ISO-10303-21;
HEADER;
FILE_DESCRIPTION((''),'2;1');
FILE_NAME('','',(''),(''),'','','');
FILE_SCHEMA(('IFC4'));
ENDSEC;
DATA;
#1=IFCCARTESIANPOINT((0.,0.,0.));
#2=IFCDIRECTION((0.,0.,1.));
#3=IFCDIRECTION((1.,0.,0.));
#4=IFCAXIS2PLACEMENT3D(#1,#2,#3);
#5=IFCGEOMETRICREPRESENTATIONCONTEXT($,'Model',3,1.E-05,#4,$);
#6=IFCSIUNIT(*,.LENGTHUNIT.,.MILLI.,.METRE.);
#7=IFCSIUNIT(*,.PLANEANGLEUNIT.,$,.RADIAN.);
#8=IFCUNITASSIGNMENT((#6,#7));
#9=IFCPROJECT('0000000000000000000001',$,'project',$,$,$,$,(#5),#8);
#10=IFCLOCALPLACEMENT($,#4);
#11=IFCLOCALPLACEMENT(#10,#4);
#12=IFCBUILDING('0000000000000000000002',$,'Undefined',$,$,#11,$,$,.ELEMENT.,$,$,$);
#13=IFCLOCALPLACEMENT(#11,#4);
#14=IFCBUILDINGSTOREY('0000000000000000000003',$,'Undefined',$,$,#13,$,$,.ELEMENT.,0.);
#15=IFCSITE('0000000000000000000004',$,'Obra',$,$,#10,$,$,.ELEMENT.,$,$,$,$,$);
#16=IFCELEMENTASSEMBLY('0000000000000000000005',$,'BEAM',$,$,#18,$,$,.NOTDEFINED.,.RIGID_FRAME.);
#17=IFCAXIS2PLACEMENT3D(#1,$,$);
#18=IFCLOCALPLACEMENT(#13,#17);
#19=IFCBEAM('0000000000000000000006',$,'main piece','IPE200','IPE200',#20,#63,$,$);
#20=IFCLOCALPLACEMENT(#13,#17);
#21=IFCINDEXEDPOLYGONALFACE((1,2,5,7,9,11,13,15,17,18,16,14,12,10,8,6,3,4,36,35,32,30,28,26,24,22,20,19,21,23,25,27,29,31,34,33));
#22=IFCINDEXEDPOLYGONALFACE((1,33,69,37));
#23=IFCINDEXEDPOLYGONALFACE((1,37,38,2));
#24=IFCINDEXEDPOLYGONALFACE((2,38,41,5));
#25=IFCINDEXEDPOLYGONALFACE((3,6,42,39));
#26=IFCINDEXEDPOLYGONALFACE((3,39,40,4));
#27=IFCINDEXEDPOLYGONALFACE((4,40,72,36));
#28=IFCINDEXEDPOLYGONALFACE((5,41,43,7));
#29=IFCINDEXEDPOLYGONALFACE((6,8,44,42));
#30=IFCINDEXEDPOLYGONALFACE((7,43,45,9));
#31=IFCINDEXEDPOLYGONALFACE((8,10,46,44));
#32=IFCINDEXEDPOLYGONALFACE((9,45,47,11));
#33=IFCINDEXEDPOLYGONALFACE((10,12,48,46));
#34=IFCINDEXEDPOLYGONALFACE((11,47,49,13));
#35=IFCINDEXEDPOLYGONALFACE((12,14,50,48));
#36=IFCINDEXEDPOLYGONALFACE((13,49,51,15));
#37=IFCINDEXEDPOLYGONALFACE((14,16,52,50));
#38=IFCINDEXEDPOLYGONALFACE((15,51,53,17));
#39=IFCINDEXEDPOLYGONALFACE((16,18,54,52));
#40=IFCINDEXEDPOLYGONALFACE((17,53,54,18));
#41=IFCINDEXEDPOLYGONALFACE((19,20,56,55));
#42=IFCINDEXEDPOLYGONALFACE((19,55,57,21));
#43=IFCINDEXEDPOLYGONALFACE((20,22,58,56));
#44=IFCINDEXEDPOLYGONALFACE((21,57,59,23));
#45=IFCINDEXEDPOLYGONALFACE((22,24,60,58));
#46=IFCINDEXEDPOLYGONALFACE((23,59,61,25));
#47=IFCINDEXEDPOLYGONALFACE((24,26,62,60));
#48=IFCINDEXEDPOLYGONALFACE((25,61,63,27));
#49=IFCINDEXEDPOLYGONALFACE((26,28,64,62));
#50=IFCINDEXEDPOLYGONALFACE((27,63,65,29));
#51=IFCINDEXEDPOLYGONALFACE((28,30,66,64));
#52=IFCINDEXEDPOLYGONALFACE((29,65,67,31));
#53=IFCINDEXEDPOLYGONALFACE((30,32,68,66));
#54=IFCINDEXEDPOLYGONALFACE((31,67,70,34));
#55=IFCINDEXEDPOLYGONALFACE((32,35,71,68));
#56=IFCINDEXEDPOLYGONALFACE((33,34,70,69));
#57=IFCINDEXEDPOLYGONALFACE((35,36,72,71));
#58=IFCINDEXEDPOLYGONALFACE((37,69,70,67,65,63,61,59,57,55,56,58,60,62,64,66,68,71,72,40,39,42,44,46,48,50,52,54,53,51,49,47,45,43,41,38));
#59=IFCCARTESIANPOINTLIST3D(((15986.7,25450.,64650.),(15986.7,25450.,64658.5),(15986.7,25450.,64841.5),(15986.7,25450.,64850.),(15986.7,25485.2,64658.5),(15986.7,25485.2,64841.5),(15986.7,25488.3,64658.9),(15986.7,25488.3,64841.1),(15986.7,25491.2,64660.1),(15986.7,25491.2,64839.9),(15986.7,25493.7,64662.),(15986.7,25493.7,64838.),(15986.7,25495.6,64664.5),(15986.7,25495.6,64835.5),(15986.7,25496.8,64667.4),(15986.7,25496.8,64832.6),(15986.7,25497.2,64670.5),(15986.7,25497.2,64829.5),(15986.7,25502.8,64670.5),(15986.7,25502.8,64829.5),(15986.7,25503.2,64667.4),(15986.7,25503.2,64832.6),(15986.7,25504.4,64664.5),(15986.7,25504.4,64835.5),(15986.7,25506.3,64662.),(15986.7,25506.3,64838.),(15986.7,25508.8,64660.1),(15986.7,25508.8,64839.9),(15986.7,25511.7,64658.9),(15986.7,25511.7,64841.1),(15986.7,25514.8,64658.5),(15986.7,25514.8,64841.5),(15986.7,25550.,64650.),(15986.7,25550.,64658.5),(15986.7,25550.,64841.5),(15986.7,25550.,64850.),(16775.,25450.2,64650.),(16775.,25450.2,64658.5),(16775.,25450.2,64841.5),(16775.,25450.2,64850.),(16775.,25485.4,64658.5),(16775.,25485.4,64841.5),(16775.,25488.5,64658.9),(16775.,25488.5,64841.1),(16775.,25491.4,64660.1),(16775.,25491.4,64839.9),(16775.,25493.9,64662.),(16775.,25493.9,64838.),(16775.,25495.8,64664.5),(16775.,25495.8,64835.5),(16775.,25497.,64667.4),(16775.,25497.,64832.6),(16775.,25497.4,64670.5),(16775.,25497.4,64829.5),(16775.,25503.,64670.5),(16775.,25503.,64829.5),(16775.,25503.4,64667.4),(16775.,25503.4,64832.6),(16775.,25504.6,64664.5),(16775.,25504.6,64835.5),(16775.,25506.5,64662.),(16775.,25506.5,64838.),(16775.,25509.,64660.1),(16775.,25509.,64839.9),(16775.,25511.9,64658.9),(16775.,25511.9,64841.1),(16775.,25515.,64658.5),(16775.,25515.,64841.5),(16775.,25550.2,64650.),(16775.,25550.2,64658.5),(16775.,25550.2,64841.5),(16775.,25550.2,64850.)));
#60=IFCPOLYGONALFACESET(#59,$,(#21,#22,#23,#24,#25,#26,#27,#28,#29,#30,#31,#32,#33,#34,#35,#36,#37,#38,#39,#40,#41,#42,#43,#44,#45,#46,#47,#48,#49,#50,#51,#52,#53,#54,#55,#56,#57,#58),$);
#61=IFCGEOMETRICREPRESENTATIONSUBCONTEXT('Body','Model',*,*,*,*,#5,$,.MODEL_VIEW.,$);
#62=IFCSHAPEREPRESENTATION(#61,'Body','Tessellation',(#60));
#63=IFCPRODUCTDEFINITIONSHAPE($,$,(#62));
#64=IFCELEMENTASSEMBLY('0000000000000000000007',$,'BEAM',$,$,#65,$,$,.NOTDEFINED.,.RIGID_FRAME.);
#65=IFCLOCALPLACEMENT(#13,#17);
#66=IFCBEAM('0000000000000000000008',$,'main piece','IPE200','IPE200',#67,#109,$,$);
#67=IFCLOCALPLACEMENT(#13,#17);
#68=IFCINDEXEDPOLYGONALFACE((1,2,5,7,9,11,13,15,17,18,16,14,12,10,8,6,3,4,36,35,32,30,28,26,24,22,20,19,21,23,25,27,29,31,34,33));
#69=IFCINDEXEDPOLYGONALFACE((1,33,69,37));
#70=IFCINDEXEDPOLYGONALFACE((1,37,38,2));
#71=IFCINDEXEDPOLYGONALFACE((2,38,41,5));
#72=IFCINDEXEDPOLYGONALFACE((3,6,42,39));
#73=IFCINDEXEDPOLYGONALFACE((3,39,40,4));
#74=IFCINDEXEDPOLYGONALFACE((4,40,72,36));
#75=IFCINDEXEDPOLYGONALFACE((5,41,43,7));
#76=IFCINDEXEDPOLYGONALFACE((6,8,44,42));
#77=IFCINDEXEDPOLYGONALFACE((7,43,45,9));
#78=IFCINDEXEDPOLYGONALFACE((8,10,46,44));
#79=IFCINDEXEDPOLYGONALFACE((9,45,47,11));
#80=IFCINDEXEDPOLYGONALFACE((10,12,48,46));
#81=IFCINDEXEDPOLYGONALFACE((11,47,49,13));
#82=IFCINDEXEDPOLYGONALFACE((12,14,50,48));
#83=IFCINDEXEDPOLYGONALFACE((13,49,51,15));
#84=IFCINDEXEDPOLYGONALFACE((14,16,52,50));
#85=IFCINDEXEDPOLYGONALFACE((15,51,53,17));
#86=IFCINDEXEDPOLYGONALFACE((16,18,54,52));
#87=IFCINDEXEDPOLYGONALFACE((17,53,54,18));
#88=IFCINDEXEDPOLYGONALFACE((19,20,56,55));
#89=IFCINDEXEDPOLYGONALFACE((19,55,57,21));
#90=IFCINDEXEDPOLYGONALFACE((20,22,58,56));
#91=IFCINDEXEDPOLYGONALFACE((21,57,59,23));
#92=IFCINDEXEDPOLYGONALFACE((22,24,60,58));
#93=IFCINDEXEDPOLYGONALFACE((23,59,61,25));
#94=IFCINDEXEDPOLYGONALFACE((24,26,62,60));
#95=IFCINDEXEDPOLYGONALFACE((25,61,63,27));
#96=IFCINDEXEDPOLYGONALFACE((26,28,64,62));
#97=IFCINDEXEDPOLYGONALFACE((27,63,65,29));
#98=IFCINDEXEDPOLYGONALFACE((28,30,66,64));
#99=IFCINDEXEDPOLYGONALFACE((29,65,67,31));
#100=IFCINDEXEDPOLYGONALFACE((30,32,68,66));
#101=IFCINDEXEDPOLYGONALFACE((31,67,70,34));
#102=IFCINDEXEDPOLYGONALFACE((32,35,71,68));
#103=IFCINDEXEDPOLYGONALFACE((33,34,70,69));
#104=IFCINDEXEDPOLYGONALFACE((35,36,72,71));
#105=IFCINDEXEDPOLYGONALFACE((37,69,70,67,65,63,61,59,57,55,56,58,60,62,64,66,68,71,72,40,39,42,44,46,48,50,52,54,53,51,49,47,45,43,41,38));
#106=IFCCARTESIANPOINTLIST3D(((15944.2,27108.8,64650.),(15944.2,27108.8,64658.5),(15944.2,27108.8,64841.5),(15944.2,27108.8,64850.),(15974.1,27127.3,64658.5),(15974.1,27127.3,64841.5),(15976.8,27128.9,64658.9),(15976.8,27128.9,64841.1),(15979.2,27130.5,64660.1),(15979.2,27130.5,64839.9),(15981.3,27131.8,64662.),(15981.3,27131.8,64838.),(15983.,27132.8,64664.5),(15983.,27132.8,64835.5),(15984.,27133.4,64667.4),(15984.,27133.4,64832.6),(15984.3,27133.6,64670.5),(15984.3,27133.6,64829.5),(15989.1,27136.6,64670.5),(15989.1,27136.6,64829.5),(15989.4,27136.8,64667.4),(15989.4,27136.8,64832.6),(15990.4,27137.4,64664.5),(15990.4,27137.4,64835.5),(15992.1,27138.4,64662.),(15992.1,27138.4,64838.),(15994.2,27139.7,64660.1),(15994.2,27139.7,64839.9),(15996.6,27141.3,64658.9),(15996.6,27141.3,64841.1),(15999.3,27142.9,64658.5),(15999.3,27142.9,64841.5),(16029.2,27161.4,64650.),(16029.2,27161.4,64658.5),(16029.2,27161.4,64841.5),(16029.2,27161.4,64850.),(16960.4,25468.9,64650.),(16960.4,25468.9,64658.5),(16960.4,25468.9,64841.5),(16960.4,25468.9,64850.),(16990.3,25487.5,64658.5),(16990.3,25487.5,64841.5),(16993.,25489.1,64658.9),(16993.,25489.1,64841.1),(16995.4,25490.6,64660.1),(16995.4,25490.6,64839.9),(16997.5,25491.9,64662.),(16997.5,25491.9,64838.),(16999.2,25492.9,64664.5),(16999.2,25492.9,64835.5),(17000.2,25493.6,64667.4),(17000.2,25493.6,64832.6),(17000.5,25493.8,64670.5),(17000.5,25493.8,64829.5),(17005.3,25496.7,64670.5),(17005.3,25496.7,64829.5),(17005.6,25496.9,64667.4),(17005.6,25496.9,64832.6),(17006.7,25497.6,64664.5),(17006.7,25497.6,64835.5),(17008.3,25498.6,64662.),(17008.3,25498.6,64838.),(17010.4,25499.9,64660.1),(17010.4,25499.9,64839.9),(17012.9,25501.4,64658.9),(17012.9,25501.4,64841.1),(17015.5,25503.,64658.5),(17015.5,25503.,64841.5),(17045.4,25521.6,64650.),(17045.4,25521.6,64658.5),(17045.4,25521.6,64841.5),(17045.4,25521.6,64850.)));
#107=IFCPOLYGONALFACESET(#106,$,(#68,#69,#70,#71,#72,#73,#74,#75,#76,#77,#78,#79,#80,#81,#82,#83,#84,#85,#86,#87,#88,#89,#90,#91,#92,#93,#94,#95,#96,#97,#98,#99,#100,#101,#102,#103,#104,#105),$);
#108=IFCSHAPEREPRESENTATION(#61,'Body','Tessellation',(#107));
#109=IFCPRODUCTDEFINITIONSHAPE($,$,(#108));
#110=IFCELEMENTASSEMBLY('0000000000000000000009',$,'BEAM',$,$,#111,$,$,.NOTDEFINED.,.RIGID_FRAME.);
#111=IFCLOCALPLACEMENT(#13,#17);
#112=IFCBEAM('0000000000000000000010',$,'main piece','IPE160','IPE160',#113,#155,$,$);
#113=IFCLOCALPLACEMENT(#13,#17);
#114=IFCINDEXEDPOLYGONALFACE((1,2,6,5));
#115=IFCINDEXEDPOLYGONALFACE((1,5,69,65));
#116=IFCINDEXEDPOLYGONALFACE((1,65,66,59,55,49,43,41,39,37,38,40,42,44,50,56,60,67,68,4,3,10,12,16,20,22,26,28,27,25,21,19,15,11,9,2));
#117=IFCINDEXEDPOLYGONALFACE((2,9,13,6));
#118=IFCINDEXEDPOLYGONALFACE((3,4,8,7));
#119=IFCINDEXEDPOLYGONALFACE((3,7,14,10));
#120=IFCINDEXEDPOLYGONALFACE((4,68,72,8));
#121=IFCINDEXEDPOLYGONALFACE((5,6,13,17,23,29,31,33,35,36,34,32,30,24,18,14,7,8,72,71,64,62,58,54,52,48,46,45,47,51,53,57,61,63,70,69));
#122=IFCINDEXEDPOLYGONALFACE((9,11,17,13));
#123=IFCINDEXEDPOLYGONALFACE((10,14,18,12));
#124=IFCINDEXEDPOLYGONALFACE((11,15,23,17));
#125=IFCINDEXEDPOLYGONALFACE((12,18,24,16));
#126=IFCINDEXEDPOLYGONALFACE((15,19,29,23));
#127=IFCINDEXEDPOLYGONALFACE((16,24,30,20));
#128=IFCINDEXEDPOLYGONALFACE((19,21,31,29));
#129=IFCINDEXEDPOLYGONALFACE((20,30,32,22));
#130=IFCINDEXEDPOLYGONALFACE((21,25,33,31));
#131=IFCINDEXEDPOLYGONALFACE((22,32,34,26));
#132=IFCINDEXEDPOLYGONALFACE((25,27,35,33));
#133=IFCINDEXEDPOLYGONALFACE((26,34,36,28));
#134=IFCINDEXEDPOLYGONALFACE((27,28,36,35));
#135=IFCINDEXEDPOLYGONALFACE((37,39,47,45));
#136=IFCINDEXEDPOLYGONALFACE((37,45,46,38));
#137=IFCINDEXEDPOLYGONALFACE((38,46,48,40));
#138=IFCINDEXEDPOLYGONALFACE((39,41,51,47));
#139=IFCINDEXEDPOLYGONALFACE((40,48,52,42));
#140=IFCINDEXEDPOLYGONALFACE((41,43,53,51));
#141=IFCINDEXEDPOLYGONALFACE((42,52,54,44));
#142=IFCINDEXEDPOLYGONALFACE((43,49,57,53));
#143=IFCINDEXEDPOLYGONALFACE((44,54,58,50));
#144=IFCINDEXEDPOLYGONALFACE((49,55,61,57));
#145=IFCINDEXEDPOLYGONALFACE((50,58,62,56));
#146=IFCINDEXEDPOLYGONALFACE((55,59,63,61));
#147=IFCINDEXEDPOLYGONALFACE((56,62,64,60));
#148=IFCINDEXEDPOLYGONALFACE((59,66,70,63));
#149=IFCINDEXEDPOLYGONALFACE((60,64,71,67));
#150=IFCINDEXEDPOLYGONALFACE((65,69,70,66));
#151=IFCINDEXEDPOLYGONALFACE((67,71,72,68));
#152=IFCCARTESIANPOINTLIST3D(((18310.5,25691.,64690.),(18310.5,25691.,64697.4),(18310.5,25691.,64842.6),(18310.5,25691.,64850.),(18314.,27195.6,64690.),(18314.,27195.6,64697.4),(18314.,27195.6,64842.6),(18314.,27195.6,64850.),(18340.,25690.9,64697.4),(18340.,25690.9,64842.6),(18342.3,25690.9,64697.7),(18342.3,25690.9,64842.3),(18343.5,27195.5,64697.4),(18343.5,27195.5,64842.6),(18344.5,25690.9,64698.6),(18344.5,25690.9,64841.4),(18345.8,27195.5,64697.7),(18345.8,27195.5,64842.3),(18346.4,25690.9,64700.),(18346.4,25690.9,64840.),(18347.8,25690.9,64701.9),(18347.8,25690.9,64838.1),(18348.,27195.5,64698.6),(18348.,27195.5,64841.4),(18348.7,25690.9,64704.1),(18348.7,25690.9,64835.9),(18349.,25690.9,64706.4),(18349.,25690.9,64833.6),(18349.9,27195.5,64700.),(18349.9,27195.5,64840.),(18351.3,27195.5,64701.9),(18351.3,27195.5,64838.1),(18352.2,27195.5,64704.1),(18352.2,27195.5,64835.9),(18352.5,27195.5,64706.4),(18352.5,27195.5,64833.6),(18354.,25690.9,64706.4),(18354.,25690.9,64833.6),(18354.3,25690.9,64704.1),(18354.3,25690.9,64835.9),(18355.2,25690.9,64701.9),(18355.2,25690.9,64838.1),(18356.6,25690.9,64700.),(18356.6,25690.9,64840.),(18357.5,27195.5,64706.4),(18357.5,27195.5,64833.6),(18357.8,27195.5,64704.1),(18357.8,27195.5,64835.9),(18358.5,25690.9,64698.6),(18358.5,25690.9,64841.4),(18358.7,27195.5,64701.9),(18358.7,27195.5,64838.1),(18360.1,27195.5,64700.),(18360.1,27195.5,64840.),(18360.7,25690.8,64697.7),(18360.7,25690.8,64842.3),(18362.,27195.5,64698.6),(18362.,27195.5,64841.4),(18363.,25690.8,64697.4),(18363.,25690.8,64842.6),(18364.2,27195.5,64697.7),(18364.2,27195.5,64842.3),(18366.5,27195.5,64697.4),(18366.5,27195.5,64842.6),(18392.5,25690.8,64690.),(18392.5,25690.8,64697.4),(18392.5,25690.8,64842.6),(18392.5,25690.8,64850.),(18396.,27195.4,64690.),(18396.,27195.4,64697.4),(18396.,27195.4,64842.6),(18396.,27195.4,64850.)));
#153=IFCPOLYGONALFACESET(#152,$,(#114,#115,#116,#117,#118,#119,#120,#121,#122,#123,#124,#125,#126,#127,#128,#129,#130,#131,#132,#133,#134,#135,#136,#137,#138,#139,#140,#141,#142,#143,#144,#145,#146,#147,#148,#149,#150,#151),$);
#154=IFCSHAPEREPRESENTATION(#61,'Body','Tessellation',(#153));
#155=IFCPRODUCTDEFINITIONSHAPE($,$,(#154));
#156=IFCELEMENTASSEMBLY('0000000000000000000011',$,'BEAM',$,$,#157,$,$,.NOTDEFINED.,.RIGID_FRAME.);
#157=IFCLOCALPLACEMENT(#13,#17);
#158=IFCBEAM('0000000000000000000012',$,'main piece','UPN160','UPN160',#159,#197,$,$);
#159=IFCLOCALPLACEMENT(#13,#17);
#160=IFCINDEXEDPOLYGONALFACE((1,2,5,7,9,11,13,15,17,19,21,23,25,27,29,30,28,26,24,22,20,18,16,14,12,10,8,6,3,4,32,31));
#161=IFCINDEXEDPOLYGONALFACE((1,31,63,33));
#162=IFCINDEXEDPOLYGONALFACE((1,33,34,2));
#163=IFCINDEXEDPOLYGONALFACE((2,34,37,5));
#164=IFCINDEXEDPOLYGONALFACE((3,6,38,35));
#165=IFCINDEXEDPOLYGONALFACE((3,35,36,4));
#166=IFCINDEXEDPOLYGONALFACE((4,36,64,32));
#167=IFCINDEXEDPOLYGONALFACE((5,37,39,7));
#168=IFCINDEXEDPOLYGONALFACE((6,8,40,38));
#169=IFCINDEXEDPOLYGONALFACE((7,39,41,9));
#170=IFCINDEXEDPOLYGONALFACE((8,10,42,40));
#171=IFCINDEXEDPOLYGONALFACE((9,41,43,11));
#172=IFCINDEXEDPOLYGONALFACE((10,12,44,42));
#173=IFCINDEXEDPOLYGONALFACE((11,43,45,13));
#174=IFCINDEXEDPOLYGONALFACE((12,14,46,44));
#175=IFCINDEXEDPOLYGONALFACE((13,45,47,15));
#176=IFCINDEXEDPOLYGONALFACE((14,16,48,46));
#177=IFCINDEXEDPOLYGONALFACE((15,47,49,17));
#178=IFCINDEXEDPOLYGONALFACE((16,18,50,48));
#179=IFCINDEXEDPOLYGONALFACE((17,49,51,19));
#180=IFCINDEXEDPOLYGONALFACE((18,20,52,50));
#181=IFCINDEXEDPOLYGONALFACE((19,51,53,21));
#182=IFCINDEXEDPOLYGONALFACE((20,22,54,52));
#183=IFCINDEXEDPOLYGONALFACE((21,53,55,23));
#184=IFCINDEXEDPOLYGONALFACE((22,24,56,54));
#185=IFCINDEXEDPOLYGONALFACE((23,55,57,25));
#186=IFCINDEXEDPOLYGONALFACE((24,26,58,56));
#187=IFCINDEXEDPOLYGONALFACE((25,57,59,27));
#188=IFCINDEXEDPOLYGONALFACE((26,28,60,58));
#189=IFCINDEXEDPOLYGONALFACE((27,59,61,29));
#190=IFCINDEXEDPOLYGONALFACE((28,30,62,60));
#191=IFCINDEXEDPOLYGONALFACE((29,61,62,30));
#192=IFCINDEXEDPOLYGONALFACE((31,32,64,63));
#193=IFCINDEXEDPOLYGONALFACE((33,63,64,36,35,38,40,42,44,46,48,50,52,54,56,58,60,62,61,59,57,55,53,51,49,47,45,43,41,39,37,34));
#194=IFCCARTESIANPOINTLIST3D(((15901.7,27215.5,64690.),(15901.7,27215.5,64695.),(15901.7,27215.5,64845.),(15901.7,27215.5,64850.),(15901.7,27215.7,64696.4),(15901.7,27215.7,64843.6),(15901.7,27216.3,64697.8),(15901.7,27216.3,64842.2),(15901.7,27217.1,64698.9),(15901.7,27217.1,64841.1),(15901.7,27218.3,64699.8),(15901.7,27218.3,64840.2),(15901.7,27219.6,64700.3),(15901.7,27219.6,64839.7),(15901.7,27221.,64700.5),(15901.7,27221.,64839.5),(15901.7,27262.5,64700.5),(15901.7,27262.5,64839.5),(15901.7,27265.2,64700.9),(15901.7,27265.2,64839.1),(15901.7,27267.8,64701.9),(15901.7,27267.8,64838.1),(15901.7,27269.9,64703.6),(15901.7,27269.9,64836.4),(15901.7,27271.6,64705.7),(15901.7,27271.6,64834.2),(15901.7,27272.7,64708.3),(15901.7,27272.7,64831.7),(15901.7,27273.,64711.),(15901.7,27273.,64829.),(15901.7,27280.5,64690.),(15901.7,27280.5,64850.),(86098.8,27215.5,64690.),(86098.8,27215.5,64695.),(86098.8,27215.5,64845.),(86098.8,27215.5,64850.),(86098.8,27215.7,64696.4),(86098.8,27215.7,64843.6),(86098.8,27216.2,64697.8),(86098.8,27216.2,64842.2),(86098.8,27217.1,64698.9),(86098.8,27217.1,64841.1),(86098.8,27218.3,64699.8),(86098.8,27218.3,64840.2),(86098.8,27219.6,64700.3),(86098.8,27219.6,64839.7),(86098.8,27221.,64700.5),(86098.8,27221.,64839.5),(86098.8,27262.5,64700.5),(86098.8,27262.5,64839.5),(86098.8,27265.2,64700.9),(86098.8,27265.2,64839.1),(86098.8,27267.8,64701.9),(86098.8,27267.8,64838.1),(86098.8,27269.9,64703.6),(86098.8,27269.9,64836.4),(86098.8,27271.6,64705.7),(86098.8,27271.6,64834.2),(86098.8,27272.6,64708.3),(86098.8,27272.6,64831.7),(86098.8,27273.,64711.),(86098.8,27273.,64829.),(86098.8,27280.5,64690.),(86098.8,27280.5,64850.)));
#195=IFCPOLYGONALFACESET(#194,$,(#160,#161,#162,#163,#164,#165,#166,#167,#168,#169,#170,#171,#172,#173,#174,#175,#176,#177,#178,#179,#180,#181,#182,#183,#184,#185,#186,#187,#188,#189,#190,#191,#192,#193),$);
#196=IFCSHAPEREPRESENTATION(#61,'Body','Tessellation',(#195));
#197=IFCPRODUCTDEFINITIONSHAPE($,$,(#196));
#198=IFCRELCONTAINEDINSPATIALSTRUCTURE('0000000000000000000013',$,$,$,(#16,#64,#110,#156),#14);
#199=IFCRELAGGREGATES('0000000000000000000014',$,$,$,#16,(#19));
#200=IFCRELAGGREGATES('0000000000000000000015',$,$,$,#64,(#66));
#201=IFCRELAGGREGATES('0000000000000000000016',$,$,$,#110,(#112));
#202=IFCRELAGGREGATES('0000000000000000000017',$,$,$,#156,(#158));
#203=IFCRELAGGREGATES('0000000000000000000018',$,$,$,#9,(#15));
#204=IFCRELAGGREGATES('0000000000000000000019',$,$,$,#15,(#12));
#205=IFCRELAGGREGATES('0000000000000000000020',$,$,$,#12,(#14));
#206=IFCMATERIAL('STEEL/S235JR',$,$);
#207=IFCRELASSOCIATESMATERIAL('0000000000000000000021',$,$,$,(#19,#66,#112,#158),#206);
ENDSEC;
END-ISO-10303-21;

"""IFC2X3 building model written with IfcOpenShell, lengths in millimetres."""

from ifc_helpers import new_model, si_unit, frame, origin_with_axes, origin_2d_with_axis, place, context, subcontext, project, spatial, i_section, u_section, extrude, material, element, aggregate, save


model = new_model("IFC2X3")

# Units and contexts
model_context = context("Model", 3, precision=1e-05, world=origin_with_axes())
body_context = subcontext(model_context, "Body", "Model", "MODEL_VIEW")
ifc_project = project(units=[si_unit("LENGTHUNIT", "METRE", prefix="MILLI"), si_unit("PLANEANGLEUNIT", "RADIAN")], contexts=[model_context])

# Site, building, storey
site_placement = place(None, origin_with_axes())
site = spatial("IfcSite", under=ifc_project, at=site_placement, Name="Obra", CompositionType="ELEMENT")
building_placement = place(site_placement, origin_with_axes())
building = spatial("IfcBuilding", under=site, at=building_placement, Name="Undefined", CompositionType="ELEMENT")
storey_placement = place(building_placement, origin_with_axes())
storey = spatial("IfcBuildingStorey", under=building, at=storey_placement, Name="Undefined", CompositionType="ELEMENT", Elevation=0.0)

# Shared definitions
ifc_material_1 = material(Name="STEEL/S235JR")

# Element assemblies, beams
assembly_1_placement = place(storey_placement, origin_with_axes())
assembly_1 = element("IfcElementAssembly", 1, at=assembly_1_placement, inside=storey, Name="BEAM", AssemblyPlace="NOTDEFINED", PredefinedType="RIGID_FRAME")
beam_1_placement = place(assembly_1_placement, frame((16775.0, 25500.2, 64750.0), z_axis=(0.0, 0.0, 1.0), x_axis=(-1.0, -0.000266, 0.0)))
beam_1 = element("IfcBeam", 2, at=beam_1_placement, material=ifc_material_1, Name="main piece", Description="IPE200", ObjectType="IPE200", context=body_context, shape_type="SweptSolid", body=[
    extrude(i_section(OverallWidth=100.0, OverallDepth=200.0, WebThickness=5.6, FlangeThickness=8.5, FilletRadius=12.0, at=origin_2d_with_axis()), frame((788.3, 0.0, 0.0), z_axis=(-1.0, 0.0, 0.0), x_axis=(0.0, -1.0, 0.0)), (0.0, 0.0, 1.0), 788.3),
])
aggregate(assembly_1, [beam_1])
assembly_2_placement = place(storey_placement, origin_with_axes())
assembly_2 = element("IfcElementAssembly", 3, at=assembly_2_placement, inside=storey, Name="BEAM", AssemblyPlace="NOTDEFINED", PredefinedType="RIGID_FRAME")
beam_2_placement = place(assembly_2_placement, frame((17002.9, 25495.3, 64750.0), z_axis=(0.0, 0.0, 1.0), x_axis=(-0.526756, 0.850017, 0.0)))
beam_2 = element("IfcBeam", 4, at=beam_2_placement, material=ifc_material_1, Name="main piece", Description="IPE200", ObjectType="IPE200", context=body_context, shape_type="SweptSolid", body=[
    extrude(i_section(OverallWidth=100.0, OverallDepth=200.0, WebThickness=5.6, FlangeThickness=8.5, FilletRadius=12.0, at=origin_2d_with_axis()), frame((1929.2, 0.0, 0.0), z_axis=(-1.0, 0.0, 0.0), x_axis=(0.0, -1.0, 0.0)), (0.0, 0.0, 1.0), 1929.2),
])
aggregate(assembly_2, [beam_2])
assembly_3_placement = place(storey_placement, origin_with_axes())
assembly_3 = element("IfcElementAssembly", 5, at=assembly_3_placement, inside=storey, Name="BEAM", AssemblyPlace="NOTDEFINED", PredefinedType="RIGID_FRAME")
beam_3_placement = place(assembly_3_placement, frame((18351.5, 25690.9, 64770.0), z_axis=(0.0, 0.0, 1.0), x_axis=(0.002325, 0.999997, 0.0)))
beam_3 = element("IfcBeam", 6, at=beam_3_placement, material=ifc_material_1, Name="main piece", Description="IPE160", ObjectType="IPE160", context=body_context, shape_type="SweptSolid", body=[
    extrude(i_section(OverallWidth=82.0, OverallDepth=160.0, WebThickness=5.0, FlangeThickness=7.4, FilletRadius=9.0, at=origin_2d_with_axis()), frame((1504.6, 0.0, 0.0), z_axis=(-1.0, 0.0, 0.0), x_axis=(0.0, -1.0, 0.0)), (0.0, 0.0, 1.0), 1504.6),
])
aggregate(assembly_3, [beam_3])
assembly_4_placement = place(storey_placement, origin_with_axes())
assembly_4 = element("IfcElementAssembly", 7, at=assembly_4_placement, inside=storey, Name="BEAM", AssemblyPlace="NOTDEFINED", PredefinedType="RIGID_FRAME")
beam_4_placement = place(assembly_4_placement, frame((15901.7, 27248.0, 64770.0), z_axis=(0.0, 0.0, 1.0), x_axis=(1.0, 0.0, 0.0)))
beam_4 = element("IfcBeam", 8, at=beam_4_placement, material=ifc_material_1, Name="main piece", Description="UPN160", ObjectType="UPN160", context=body_context, shape_type="SweptSolid", body=[
    extrude(u_section(Depth=160.0, FlangeWidth=65.0, WebThickness=7.5, FlangeThickness=10.5, FilletRadius=10.5, EdgeRadius=5.5, at=origin_2d_with_axis()), frame((70197.1, 0.0, 0.0), z_axis=(-1.0, 0.0, 0.0), x_axis=(0.0, -1.0, 0.0)), (0.0, 0.0, 1.0), 70197.1),
])
aggregate(assembly_4, [beam_4])

save(model, "model.ifc")
